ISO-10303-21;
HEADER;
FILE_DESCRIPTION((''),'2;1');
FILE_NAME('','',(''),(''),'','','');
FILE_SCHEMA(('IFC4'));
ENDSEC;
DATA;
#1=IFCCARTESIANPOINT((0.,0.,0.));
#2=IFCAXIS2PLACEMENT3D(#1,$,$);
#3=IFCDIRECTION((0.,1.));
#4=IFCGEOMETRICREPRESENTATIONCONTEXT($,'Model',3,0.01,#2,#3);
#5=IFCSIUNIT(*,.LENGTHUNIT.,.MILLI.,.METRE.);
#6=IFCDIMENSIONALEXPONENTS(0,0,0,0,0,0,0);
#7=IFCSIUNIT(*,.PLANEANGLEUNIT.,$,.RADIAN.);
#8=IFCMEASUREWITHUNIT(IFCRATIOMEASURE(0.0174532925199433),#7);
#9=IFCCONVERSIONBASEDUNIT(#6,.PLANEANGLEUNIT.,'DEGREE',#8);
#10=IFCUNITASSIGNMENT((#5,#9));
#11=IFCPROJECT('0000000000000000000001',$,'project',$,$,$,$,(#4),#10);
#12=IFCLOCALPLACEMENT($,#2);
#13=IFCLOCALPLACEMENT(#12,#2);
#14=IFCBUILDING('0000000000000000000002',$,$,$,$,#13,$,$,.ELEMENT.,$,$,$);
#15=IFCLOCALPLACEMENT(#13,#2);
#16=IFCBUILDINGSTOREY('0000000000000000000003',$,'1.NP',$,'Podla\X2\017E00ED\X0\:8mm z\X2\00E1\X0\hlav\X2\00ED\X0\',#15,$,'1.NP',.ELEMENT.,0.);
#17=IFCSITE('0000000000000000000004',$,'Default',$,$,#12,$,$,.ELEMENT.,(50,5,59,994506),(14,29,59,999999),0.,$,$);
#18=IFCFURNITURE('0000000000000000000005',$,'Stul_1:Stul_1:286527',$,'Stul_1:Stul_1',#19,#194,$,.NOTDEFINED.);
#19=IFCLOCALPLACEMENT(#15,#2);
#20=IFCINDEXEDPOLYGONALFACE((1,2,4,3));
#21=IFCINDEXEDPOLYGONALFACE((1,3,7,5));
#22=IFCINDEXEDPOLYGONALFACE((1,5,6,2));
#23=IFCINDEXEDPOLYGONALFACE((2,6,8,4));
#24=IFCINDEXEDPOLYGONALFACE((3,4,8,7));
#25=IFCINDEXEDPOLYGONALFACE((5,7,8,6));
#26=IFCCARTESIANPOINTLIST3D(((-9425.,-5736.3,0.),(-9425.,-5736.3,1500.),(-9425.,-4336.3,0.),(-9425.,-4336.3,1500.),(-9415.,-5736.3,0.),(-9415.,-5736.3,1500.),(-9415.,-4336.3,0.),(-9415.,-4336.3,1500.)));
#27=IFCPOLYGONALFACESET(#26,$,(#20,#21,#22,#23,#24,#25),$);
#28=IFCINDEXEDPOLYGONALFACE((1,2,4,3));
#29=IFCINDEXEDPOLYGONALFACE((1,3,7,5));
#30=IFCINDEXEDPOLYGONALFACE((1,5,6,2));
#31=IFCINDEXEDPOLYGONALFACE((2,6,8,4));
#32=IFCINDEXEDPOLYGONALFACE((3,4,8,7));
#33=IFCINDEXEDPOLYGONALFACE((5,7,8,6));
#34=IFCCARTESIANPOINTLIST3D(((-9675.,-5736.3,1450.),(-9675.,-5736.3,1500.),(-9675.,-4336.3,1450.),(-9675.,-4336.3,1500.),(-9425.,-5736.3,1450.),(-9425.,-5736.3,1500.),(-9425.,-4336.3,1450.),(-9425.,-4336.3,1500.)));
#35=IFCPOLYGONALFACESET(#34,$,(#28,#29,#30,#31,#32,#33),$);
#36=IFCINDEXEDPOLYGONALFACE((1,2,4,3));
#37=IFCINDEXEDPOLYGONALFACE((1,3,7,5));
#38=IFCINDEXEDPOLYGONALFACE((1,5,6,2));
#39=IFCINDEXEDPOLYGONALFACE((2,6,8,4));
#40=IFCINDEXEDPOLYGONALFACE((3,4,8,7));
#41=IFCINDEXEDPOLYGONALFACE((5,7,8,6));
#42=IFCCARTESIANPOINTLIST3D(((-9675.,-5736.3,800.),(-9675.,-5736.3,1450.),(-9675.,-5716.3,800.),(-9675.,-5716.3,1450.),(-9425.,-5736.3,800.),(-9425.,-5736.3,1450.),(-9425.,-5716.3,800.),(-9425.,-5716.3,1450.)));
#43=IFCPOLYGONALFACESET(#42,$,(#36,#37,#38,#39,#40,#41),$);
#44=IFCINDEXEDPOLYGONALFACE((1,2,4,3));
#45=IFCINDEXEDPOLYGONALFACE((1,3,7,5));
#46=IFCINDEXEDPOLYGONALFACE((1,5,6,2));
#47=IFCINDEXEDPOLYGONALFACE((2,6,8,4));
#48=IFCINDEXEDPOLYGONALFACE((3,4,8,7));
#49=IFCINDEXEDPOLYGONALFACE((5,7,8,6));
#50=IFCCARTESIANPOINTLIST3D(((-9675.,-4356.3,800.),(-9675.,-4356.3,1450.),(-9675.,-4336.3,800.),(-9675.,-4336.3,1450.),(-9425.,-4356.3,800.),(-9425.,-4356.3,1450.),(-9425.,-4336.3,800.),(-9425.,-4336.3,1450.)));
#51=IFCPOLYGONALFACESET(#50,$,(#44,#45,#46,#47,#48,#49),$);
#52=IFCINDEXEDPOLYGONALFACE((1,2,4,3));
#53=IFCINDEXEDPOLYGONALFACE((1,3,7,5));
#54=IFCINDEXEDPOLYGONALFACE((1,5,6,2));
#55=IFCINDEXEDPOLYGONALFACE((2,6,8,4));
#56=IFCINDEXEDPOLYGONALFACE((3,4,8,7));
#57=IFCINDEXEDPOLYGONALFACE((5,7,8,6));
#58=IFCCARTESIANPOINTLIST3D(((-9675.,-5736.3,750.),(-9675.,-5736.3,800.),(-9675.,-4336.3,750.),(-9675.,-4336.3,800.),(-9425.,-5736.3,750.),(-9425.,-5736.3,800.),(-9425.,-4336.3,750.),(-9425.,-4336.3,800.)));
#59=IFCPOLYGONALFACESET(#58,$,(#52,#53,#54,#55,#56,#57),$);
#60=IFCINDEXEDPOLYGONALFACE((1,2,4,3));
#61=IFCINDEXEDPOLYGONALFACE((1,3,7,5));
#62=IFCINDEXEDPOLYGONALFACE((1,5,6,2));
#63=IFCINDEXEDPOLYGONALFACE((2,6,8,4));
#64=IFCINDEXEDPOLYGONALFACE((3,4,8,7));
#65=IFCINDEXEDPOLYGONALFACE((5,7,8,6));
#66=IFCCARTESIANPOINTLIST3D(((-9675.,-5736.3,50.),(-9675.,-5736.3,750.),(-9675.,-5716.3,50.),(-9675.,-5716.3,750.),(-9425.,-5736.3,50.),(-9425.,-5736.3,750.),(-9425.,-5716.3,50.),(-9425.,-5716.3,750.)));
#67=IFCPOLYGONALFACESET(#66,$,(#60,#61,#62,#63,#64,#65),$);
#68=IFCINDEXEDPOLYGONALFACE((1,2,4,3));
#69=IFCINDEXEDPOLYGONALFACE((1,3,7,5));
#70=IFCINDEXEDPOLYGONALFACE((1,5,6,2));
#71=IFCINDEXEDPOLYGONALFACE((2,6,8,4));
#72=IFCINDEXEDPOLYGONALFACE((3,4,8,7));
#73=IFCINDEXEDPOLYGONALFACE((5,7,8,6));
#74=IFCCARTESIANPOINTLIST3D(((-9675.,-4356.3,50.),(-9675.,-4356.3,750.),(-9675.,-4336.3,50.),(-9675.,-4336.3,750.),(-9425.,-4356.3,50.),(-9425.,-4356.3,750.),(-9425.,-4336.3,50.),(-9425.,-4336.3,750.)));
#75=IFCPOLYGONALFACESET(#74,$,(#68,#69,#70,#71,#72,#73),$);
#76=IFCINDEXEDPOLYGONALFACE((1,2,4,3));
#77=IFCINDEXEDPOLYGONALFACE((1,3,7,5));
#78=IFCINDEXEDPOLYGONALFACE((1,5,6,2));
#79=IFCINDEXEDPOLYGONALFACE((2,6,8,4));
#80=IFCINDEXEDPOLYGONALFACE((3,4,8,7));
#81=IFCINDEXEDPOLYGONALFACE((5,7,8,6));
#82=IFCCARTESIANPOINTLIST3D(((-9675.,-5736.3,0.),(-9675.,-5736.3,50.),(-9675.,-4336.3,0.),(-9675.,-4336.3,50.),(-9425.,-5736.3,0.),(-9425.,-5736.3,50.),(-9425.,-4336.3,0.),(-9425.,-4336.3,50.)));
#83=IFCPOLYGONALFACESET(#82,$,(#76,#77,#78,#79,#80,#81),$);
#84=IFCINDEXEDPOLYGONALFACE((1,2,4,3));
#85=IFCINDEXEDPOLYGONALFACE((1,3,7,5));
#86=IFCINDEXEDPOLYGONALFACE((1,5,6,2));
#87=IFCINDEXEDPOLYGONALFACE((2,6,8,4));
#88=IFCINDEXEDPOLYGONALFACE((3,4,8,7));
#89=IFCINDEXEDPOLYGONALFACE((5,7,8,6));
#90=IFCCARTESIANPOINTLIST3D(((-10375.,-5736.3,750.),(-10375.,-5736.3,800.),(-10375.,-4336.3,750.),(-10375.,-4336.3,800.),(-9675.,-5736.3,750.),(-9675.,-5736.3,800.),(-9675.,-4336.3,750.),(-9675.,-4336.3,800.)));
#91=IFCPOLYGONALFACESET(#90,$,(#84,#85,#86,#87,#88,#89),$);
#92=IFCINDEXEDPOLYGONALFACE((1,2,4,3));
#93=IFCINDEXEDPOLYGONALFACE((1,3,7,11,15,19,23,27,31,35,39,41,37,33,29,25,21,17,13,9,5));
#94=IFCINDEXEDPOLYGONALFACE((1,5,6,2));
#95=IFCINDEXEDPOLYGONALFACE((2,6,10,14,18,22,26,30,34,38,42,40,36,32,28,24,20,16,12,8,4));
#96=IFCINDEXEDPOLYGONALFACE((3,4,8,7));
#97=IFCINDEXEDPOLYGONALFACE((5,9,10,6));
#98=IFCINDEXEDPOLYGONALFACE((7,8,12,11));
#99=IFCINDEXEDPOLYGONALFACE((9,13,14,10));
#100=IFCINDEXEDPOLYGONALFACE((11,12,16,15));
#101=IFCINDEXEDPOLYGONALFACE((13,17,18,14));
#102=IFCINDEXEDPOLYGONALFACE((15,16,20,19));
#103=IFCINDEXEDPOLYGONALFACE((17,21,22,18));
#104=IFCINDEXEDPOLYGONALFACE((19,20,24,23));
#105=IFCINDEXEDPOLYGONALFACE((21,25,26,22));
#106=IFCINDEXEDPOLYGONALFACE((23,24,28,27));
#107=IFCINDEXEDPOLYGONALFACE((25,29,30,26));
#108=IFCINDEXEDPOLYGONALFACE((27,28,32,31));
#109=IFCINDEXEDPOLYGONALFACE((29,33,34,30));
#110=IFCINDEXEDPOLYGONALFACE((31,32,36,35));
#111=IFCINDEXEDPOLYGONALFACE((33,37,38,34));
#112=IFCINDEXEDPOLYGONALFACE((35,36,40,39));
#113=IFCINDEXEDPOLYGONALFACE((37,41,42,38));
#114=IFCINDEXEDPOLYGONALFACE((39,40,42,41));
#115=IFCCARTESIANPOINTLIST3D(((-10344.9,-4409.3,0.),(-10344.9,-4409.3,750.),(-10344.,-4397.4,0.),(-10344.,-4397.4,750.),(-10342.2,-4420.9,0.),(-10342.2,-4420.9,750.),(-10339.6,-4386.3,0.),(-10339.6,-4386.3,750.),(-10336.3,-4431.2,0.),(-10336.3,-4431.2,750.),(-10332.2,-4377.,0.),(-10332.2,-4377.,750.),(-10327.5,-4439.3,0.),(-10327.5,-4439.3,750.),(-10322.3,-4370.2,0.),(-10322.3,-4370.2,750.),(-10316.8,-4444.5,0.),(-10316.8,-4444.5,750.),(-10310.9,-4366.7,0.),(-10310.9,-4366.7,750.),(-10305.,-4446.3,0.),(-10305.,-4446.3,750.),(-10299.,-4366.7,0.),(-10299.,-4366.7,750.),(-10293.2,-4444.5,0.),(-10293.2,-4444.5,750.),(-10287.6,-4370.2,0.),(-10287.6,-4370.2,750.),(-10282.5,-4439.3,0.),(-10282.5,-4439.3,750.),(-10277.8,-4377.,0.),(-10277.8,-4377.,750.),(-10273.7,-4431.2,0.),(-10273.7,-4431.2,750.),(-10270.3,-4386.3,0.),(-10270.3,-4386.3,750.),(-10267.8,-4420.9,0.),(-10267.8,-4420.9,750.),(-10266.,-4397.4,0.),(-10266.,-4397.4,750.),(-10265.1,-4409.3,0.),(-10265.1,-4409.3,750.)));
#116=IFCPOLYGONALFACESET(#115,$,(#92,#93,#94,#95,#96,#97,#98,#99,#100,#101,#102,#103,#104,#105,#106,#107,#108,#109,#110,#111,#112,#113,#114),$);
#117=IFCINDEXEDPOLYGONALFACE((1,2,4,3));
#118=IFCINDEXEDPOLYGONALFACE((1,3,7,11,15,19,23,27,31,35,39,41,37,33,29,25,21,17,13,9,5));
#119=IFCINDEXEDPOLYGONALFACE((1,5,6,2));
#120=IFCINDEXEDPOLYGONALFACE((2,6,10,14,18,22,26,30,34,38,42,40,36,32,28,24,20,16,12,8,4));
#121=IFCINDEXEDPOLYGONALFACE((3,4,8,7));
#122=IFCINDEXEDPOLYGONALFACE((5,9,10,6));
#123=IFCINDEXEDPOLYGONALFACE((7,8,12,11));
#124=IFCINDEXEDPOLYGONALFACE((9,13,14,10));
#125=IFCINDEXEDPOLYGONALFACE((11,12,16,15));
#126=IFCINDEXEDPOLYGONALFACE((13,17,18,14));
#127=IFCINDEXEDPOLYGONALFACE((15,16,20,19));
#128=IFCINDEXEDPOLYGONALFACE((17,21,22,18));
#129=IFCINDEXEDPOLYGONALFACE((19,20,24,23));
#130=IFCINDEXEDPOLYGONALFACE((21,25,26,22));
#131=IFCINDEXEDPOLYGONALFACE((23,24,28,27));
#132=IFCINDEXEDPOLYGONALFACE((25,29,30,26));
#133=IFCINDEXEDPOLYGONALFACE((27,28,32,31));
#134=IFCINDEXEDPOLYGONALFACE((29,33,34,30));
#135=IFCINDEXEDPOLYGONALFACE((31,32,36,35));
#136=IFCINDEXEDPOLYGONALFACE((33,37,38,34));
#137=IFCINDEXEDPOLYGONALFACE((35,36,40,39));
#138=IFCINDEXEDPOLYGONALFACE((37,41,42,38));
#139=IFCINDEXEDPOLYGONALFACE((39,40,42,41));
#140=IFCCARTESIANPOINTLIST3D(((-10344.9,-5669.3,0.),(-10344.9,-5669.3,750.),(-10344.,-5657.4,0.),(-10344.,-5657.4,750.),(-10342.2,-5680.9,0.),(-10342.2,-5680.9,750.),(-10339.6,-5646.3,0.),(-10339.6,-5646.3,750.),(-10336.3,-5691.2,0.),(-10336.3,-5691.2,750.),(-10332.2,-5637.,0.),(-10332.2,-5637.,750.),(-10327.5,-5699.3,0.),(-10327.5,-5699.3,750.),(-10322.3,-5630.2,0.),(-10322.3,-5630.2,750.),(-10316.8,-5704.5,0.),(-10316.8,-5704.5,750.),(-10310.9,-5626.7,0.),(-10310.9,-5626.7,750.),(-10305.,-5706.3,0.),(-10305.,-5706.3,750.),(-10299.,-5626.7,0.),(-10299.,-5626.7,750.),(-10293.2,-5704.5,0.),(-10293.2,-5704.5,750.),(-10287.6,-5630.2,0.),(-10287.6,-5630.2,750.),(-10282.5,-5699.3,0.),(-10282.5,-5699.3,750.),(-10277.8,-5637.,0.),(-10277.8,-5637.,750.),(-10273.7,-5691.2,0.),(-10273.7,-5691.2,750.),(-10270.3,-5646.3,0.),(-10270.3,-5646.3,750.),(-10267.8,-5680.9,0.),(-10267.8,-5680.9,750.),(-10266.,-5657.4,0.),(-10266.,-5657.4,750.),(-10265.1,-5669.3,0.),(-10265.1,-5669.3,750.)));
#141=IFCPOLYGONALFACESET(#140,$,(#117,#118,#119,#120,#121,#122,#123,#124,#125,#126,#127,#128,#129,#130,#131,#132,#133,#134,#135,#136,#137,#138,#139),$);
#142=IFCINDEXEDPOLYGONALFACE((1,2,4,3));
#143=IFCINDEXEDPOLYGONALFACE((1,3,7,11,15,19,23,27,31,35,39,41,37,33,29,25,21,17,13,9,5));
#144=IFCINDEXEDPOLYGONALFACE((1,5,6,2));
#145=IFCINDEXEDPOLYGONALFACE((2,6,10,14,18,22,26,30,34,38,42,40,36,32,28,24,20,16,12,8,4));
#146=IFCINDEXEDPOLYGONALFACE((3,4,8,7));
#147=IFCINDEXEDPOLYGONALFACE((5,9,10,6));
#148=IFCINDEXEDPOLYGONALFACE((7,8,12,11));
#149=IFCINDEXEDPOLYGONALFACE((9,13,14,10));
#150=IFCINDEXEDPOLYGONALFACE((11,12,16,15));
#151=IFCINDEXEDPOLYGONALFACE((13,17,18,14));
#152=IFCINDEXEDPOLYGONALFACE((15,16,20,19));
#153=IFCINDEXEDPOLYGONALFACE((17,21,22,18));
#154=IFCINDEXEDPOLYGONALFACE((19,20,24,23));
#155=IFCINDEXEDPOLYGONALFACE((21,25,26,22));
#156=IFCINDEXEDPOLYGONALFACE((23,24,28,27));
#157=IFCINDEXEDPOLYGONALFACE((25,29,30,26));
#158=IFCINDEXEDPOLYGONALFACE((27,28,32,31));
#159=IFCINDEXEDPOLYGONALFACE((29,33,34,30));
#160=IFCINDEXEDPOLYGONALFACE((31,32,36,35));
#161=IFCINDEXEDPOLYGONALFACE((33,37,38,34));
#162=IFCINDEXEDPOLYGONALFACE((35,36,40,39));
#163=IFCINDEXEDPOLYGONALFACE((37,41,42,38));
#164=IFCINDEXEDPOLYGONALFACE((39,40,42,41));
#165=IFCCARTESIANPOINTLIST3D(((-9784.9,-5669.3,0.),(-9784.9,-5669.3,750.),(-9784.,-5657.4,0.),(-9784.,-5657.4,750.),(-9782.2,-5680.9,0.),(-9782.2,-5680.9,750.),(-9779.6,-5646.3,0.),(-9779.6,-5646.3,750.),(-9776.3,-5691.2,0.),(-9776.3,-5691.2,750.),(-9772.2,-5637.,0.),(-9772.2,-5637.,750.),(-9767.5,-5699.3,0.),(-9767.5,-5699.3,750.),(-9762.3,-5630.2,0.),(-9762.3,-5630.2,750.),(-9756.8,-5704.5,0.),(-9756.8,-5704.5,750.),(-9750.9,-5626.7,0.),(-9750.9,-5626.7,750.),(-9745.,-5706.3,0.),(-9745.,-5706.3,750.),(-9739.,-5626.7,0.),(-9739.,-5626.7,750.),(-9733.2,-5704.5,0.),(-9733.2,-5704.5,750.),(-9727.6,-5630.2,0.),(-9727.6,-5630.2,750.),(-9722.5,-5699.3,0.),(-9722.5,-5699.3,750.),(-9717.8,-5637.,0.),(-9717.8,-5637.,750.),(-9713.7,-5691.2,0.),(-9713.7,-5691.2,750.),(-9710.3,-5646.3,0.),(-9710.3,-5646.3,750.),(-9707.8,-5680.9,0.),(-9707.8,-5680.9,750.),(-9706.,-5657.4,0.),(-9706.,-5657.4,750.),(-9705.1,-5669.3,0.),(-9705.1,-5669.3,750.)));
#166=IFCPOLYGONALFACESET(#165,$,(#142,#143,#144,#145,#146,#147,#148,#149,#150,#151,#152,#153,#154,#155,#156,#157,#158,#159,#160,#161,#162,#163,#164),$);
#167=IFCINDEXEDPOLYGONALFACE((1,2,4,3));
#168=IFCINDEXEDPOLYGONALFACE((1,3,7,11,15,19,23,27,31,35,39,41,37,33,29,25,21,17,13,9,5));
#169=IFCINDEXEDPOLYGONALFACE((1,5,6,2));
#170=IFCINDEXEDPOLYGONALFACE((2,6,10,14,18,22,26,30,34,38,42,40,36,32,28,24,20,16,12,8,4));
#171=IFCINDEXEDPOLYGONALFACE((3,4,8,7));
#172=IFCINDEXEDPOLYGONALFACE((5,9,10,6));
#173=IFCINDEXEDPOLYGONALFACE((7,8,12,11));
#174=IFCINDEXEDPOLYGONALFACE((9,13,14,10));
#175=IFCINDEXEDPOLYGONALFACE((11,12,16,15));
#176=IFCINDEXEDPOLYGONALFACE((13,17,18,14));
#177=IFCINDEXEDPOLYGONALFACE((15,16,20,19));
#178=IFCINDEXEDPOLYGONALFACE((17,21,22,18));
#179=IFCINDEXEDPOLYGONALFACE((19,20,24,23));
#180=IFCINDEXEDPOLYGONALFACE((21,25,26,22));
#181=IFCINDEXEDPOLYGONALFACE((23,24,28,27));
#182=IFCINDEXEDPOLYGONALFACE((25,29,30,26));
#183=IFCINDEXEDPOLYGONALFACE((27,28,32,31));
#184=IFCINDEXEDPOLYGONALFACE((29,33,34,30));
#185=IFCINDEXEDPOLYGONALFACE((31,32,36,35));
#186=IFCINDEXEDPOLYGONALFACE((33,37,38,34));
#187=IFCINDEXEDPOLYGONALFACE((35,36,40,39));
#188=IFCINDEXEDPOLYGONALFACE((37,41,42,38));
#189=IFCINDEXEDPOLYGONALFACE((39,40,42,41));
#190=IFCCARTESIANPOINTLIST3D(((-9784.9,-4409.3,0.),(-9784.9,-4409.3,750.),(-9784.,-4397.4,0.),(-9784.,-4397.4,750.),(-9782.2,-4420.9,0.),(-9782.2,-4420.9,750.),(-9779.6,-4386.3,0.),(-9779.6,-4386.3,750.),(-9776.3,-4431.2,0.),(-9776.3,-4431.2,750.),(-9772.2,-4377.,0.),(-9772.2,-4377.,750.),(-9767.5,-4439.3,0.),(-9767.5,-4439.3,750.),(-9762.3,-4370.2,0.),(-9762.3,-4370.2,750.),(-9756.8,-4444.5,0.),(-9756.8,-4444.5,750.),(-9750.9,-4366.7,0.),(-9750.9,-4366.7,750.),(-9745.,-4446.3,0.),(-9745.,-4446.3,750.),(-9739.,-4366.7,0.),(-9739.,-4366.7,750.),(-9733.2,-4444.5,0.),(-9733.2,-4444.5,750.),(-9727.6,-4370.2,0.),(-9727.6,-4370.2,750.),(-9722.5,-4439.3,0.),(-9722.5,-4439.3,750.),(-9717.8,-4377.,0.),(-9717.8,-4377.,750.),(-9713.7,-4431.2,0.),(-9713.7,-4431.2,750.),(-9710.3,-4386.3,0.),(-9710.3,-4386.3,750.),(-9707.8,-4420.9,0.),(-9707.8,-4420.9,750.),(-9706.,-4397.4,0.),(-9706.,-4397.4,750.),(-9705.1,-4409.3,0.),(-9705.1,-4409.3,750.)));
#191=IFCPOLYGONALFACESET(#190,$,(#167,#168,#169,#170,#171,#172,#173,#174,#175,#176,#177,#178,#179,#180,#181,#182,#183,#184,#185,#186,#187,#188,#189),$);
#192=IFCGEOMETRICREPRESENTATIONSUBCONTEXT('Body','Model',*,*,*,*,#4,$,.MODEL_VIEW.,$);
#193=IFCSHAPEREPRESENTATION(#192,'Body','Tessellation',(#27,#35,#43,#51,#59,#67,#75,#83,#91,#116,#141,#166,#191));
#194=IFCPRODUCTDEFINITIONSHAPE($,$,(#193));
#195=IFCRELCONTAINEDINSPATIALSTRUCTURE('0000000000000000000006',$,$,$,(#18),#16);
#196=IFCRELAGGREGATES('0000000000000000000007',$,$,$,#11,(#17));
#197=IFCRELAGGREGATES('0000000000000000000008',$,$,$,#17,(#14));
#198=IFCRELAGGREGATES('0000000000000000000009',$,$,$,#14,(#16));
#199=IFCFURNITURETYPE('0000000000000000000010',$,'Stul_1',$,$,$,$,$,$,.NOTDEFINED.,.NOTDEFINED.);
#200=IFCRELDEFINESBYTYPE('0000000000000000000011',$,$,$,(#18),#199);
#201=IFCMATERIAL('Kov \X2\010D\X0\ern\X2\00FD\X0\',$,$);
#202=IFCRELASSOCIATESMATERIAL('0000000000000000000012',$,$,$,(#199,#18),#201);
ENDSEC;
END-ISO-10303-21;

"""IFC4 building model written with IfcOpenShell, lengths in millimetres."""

from ifc_helpers import new_model, entity, si_unit, converted_unit, direction, frame, frame_2d, origin, origin_2d_with_axis, place, context, subcontext, project, spatial, rectangle, circle, extrude, source, transform, mapped, material, type_object, type_shapes, element, save


model = new_model("IFC4")

# Units and contexts
model_context = context("Model", 3, precision=0.01, world=origin(), true_north=direction((0.0, 1.0)))
body_context = subcontext(model_context, "Body", "Model", "MODEL_VIEW")
ifc_project = project(units=[si_unit("LENGTHUNIT", "METRE", prefix="MILLI"), converted_unit("PLANEANGLEUNIT", "DEGREE", entity("IfcRatioMeasure", 0.0174532925199433), si_unit("PLANEANGLEUNIT", "RADIAN"), dimensions=[0, 0, 0, 0, 0, 0, 0])], contexts=[model_context])

# Site, building, storey
site_placement = place(None, origin())
site = spatial("IfcSite", under=ifc_project, at=site_placement, Name="Default", CompositionType="ELEMENT", RefLatitude=(50, 5, 59, 994506), RefLongitude=(14, 29, 59, 999999), RefElevation=0.0)
building_placement = place(site_placement, origin())
building = spatial("IfcBuilding", under=site, at=building_placement, CompositionType="ELEMENT")
storey_placement = place(building_placement, origin())
storey = spatial("IfcBuildingStorey", under=building, at=storey_placement, Name="1.NP", ObjectType="Podlaží:8mm záhlaví", LongName="1.NP", CompositionType="ELEMENT", Elevation=0.0)

# Furniture
ifc_material_1 = material(Name="Kov černý")
furniture_type = type_object("IfcFurnitureType", Name="Stul_1", AssemblyPlace="NOTDEFINED", PredefinedType="NOTDEFINED", material=ifc_material_1)
shared_shape_1 = source(origin(), body_context, "Body", "SweptSolid", [
    extrude(rectangle(XDim=1400.0, YDim=10.0, at=origin_2d_with_axis()), frame((0.0, 605.0, 0.0), z_axis=(0.0, 0.0, 1.0), x_axis=(-1.0, 0.0, 0.0)), (0.0, 0.0, 1.0), 1500.0),
    extrude(rectangle(XDim=1400.0, YDim=250.0, at=frame_2d((0.0, 0.0), x_axis=(1.0, 0.0))), frame((0.0, 475.0, 1450.0), z_axis=(0.0, 0.0, 1.0), x_axis=(-1.0, 0.0, 0.0)), (0.0, 0.0, 1.0), 50.0),
    extrude(rectangle(XDim=20.0, YDim=250.0, at=origin_2d_with_axis()), frame((690.0, 475.0, 800.0), z_axis=(0.0, 0.0, 1.0), x_axis=(-1.0, 0.0, 0.0)), (0.0, 0.0, 1.0), 650.0),
    extrude(rectangle(XDim=20.0, YDim=250.0, at=frame_2d((0.0, 0.0), x_axis=(1.0, 0.0))), frame((-690.0, 475.0, 800.0), z_axis=(0.0, 0.0, 1.0), x_axis=(-1.0, 0.0, 0.0)), (0.0, 0.0, 1.0), 650.0),
    extrude(rectangle(XDim=1400.0, YDim=250.0, at=origin_2d_with_axis()), frame((0.0, 475.0, 750.0), z_axis=(0.0, 0.0, 1.0), x_axis=(-1.0, 0.0, 0.0)), (0.0, 0.0, 1.0), 50.0),
    extrude(rectangle(XDim=20.0, YDim=250.0, at=origin_2d_with_axis()), frame((690.0, 475.0, 50.0), z_axis=(0.0, 0.0, 1.0), x_axis=(-1.0, 0.0, 0.0)), (0.0, 0.0, 1.0), 700.0),
    extrude(rectangle(XDim=20.0, YDim=250.0, at=frame_2d((0.0, 0.0), x_axis=(1.0, 0.0))), frame((-690.0, 475.0, 50.0), z_axis=(0.0, 0.0, 1.0), x_axis=(-1.0, 0.0, 0.0)), (0.0, 0.0, 1.0), 700.0),
    extrude(rectangle(XDim=1400.0, YDim=250.0, at=origin_2d_with_axis()), frame((0.0, 475.0, 0.0), z_axis=(0.0, 0.0, 1.0), x_axis=(-1.0, 0.0, 0.0)), (0.0, 0.0, 1.0), 50.0),
    extrude(rectangle(XDim=1400.0, YDim=700.0, at=origin_2d_with_axis()), frame((0.0, 0.0, 750.0), z_axis=(0.0, 0.0, 1.0), x_axis=(-1.0, 0.0, 0.0)), (0.0, 0.0, 1.0), 50.0),
    extrude(circle(Radius=40.0, at=frame_2d((0.0, 0.0), x_axis=(1.0, 0.0))), frame((-630.0, -280.0, 0.0)), (0.0, 0.0, 1.0), 750.0),
    extrude(circle(Radius=40.0, at=frame_2d((0.0, 0.0), x_axis=(1.0, 0.0))), frame((630.0, -280.0, 0.0)), (0.0, 0.0, 1.0), 750.0),
    extrude(circle(Radius=40.0, at=frame_2d((0.0, 0.0), x_axis=(1.0, 0.0))), frame((630.0, 280.0, 0.0)), (0.0, 0.0, 1.0), 750.0),
    extrude(circle(Radius=40.0, at=frame_2d((0.0, 0.0), x_axis=(1.0, 0.0))), frame((-630.0, 280.0, 0.0)), (0.0, 0.0, 1.0), 750.0),
])
type_shapes(furniture_type, [shared_shape_1])
for number, where, z_axis, x_axis, name in (
    (1, (-10025.0, -5036.3, 0.0), (0.0, 0.0, 1.0), (0.0, -1.0, 0.0), "Stul_1:Stul_1:286527"),
):
    element("IfcFurniture", number, at=place(storey_placement, frame(where, z_axis=z_axis, x_axis=x_axis)), inside=storey, type_object=furniture_type, material=ifc_material_1, Name=name, ObjectType="Stul_1:Stul_1", PredefinedType="NOTDEFINED", context=body_context, shape_type="MappedRepresentation", body=[
        mapped(shared_shape_1, transform((0.0, 0.0, 0.0), scale=1.0)),
    ])

save(model, "model.ifc")
